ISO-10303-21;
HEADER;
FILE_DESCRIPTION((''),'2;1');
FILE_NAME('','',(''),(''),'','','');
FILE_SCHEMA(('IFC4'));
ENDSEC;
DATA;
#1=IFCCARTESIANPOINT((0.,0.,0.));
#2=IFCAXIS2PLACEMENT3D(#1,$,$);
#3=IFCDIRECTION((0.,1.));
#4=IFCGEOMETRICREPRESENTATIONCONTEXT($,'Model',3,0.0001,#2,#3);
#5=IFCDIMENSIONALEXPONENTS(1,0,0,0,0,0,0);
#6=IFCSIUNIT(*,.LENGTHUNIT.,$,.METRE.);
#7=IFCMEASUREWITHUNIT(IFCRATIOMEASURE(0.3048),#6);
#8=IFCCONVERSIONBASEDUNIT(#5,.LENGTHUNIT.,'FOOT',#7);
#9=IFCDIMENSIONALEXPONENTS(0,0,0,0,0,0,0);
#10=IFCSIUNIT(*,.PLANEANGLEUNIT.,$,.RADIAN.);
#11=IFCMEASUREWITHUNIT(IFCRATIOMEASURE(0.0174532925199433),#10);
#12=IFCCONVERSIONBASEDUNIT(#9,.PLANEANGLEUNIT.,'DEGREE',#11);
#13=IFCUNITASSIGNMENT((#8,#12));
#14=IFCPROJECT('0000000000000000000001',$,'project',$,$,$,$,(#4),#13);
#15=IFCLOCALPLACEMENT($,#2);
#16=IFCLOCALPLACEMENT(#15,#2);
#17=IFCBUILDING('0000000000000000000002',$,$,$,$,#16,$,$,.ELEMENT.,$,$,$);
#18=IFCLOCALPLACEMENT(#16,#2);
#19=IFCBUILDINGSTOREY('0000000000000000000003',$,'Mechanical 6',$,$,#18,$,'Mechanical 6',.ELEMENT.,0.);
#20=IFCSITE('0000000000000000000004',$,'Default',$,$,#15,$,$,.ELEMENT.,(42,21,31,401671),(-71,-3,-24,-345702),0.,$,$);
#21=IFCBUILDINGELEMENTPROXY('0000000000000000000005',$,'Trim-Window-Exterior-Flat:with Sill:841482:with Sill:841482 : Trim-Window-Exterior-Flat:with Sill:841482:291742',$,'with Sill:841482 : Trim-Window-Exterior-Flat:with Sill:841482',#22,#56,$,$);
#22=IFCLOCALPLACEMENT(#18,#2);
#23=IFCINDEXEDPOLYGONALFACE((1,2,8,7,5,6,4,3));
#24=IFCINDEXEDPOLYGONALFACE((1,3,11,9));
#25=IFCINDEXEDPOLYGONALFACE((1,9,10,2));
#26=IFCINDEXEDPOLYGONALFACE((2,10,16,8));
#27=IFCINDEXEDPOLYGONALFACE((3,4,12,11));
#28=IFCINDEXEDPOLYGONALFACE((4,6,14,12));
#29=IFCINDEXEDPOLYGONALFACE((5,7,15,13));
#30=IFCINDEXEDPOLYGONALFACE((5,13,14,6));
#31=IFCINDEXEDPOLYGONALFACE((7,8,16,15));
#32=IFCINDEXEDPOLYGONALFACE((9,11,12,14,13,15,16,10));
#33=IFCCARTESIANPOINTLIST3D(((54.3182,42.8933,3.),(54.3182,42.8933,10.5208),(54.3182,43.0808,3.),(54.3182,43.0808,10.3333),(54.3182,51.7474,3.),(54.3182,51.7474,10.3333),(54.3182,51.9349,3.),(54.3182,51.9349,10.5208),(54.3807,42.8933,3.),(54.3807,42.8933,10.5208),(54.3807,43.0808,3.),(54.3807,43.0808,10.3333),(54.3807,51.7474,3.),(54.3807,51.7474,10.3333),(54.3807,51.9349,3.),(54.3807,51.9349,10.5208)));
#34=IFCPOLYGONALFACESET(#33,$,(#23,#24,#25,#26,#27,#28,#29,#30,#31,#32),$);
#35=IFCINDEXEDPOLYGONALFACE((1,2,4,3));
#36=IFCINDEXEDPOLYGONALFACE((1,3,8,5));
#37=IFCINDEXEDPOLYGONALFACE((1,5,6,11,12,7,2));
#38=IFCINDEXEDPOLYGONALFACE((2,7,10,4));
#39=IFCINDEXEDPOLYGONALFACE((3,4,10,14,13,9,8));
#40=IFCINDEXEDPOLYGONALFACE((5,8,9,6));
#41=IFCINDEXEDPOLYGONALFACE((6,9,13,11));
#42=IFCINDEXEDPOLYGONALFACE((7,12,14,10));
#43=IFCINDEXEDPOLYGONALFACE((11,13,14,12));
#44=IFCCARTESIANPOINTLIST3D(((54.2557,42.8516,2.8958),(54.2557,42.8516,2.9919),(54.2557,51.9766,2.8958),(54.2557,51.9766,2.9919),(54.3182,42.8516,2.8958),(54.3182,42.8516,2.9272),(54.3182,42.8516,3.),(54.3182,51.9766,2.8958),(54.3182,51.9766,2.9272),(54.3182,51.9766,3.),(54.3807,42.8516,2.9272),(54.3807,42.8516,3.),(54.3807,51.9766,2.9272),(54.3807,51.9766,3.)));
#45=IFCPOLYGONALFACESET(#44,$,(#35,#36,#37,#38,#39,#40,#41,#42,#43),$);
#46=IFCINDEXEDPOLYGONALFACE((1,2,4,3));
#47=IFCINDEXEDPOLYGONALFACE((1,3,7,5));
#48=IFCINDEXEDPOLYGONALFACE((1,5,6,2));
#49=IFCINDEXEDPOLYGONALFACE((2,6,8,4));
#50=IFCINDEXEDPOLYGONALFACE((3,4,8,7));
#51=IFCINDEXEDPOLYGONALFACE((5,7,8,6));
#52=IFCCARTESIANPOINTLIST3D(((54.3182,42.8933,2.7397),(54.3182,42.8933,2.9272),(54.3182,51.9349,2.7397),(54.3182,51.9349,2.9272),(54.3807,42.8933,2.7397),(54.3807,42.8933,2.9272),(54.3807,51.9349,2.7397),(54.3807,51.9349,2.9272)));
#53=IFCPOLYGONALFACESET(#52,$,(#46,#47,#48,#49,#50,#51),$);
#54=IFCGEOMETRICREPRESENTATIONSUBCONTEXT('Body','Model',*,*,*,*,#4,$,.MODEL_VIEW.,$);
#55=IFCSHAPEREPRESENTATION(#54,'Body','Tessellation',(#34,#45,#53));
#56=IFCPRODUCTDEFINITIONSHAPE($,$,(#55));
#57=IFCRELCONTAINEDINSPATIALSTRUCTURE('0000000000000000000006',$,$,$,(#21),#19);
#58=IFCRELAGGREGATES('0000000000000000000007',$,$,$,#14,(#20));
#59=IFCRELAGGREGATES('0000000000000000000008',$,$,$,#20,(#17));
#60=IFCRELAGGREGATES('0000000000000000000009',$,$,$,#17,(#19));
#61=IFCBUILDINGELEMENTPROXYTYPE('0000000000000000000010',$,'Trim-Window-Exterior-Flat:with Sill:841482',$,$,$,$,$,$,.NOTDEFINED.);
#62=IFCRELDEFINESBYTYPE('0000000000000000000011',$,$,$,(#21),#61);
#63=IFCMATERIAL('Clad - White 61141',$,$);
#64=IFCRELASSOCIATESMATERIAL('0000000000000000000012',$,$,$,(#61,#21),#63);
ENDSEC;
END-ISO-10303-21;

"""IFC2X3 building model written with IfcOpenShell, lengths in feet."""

from ifc_helpers import new_model, entity, si_unit, converted_unit, direction, frame, origin, origin_2d_with_axis, place, context, subcontext, project, spatial, polyline, rectangle, outline, extrude, source, transform, mapped, material, type_object, type_shapes, element, save


model = new_model("IFC2X3")

# Units and contexts
model_context = context("Model", 3, precision=0.0001, world=origin(), true_north=direction((0.0, 1.0)))
body_context = subcontext(model_context, "Body", "Model", "MODEL_VIEW")
ifc_project = project(units=[converted_unit("LENGTHUNIT", "FOOT", entity("IfcRatioMeasure", 0.3048), si_unit("LENGTHUNIT", "METRE"), dimensions=[1, 0, 0, 0, 0, 0, 0]), converted_unit("PLANEANGLEUNIT", "DEGREE", entity("IfcRatioMeasure", 0.0174532925199433), si_unit("PLANEANGLEUNIT", "RADIAN"), dimensions=[0, 0, 0, 0, 0, 0, 0])], contexts=[model_context])

# Site, building, storey
site_placement = place(None, origin())
site = spatial("IfcSite", under=ifc_project, at=site_placement, Name="Default", CompositionType="ELEMENT", RefLatitude=(42, 21, 31, 401671), RefLongitude=(-71, -3, -24, -345702), RefElevation=0.0)
building_placement = place(site_placement, origin())
building = spatial("IfcBuilding", under=site, at=building_placement, CompositionType="ELEMENT")
storey_placement = place(building_placement, origin())
storey = spatial("IfcBuildingStorey", under=building, at=storey_placement, Name="Mechanical 6", LongName="Mechanical 6", CompositionType="ELEMENT", Elevation=0.0)

# Building element proxy
ifc_material_1 = material(Name="Clad - White 61141")
building_element_proxy_type_1 = type_object("IfcBuildingElementProxyType", Name="Trim-Window-Exterior-Flat:with Sill:841482", PredefinedType="NOTDEFINED", material=ifc_material_1)
shared_shape_1 = source(origin(), body_context, "Body", "SweptSolid", [
    extrude(outline(polyline([(-3.7135, -4.5208), (3.8073, -4.5208), (3.8073, 4.5208), (-3.7135, 4.5208), (-3.7135, 4.3333), (3.6198, 4.3333), (3.6198, -4.3333), (-3.7135, -4.3333), (-3.7135, -4.5208)])), frame((54.3182, 47.4141, 6.7135), z_axis=(1.0, 0.0, 0.0), x_axis=(0.0, 0.0, 1.0)), (0.0, 0.0, 1.0), 0.0625),
    extrude(outline(polyline([(0.0, -0.0525), (0.0625, -0.0525), (0.0625, 0.0436), (0.0, 0.0517), (-0.0625, 0.0517), (-0.0625, -0.0211), (0.0, -0.0211), (0.0, -0.0525)])), frame((54.3182, 42.8516, 2.9483), z_axis=(0.0, 1.0, 0.0), x_axis=(-1.0, 0.0, 0.0)), (0.0, 0.0, 1.0), 9.125),
    extrude(rectangle(XDim=0.0625, YDim=9.0417, at=origin_2d_with_axis()), frame((54.3494, 47.4141, 2.7397)), (0.0, 0.0, 1.0), 0.1875),
])
type_shapes(building_element_proxy_type_1, [shared_shape_1])
proxy_1_placement = place(building_placement, origin())
element("IfcBuildingElementProxy", 1, at=proxy_1_placement, inside=storey, type_object=building_element_proxy_type_1, material=ifc_material_1, Name="Trim-Window-Exterior-Flat:with Sill:841482:with Sill:841482 : Trim-Window-Exterior-Flat:with Sill:841482:291742", ObjectType="with Sill:841482 : Trim-Window-Exterior-Flat:with Sill:841482", context=body_context, shape_type="MappedRepresentation", body=[
    mapped(shared_shape_1, transform((0.0, 0.0, 0.0), scale=1.0)),
])

save(model, "model.ifc")
